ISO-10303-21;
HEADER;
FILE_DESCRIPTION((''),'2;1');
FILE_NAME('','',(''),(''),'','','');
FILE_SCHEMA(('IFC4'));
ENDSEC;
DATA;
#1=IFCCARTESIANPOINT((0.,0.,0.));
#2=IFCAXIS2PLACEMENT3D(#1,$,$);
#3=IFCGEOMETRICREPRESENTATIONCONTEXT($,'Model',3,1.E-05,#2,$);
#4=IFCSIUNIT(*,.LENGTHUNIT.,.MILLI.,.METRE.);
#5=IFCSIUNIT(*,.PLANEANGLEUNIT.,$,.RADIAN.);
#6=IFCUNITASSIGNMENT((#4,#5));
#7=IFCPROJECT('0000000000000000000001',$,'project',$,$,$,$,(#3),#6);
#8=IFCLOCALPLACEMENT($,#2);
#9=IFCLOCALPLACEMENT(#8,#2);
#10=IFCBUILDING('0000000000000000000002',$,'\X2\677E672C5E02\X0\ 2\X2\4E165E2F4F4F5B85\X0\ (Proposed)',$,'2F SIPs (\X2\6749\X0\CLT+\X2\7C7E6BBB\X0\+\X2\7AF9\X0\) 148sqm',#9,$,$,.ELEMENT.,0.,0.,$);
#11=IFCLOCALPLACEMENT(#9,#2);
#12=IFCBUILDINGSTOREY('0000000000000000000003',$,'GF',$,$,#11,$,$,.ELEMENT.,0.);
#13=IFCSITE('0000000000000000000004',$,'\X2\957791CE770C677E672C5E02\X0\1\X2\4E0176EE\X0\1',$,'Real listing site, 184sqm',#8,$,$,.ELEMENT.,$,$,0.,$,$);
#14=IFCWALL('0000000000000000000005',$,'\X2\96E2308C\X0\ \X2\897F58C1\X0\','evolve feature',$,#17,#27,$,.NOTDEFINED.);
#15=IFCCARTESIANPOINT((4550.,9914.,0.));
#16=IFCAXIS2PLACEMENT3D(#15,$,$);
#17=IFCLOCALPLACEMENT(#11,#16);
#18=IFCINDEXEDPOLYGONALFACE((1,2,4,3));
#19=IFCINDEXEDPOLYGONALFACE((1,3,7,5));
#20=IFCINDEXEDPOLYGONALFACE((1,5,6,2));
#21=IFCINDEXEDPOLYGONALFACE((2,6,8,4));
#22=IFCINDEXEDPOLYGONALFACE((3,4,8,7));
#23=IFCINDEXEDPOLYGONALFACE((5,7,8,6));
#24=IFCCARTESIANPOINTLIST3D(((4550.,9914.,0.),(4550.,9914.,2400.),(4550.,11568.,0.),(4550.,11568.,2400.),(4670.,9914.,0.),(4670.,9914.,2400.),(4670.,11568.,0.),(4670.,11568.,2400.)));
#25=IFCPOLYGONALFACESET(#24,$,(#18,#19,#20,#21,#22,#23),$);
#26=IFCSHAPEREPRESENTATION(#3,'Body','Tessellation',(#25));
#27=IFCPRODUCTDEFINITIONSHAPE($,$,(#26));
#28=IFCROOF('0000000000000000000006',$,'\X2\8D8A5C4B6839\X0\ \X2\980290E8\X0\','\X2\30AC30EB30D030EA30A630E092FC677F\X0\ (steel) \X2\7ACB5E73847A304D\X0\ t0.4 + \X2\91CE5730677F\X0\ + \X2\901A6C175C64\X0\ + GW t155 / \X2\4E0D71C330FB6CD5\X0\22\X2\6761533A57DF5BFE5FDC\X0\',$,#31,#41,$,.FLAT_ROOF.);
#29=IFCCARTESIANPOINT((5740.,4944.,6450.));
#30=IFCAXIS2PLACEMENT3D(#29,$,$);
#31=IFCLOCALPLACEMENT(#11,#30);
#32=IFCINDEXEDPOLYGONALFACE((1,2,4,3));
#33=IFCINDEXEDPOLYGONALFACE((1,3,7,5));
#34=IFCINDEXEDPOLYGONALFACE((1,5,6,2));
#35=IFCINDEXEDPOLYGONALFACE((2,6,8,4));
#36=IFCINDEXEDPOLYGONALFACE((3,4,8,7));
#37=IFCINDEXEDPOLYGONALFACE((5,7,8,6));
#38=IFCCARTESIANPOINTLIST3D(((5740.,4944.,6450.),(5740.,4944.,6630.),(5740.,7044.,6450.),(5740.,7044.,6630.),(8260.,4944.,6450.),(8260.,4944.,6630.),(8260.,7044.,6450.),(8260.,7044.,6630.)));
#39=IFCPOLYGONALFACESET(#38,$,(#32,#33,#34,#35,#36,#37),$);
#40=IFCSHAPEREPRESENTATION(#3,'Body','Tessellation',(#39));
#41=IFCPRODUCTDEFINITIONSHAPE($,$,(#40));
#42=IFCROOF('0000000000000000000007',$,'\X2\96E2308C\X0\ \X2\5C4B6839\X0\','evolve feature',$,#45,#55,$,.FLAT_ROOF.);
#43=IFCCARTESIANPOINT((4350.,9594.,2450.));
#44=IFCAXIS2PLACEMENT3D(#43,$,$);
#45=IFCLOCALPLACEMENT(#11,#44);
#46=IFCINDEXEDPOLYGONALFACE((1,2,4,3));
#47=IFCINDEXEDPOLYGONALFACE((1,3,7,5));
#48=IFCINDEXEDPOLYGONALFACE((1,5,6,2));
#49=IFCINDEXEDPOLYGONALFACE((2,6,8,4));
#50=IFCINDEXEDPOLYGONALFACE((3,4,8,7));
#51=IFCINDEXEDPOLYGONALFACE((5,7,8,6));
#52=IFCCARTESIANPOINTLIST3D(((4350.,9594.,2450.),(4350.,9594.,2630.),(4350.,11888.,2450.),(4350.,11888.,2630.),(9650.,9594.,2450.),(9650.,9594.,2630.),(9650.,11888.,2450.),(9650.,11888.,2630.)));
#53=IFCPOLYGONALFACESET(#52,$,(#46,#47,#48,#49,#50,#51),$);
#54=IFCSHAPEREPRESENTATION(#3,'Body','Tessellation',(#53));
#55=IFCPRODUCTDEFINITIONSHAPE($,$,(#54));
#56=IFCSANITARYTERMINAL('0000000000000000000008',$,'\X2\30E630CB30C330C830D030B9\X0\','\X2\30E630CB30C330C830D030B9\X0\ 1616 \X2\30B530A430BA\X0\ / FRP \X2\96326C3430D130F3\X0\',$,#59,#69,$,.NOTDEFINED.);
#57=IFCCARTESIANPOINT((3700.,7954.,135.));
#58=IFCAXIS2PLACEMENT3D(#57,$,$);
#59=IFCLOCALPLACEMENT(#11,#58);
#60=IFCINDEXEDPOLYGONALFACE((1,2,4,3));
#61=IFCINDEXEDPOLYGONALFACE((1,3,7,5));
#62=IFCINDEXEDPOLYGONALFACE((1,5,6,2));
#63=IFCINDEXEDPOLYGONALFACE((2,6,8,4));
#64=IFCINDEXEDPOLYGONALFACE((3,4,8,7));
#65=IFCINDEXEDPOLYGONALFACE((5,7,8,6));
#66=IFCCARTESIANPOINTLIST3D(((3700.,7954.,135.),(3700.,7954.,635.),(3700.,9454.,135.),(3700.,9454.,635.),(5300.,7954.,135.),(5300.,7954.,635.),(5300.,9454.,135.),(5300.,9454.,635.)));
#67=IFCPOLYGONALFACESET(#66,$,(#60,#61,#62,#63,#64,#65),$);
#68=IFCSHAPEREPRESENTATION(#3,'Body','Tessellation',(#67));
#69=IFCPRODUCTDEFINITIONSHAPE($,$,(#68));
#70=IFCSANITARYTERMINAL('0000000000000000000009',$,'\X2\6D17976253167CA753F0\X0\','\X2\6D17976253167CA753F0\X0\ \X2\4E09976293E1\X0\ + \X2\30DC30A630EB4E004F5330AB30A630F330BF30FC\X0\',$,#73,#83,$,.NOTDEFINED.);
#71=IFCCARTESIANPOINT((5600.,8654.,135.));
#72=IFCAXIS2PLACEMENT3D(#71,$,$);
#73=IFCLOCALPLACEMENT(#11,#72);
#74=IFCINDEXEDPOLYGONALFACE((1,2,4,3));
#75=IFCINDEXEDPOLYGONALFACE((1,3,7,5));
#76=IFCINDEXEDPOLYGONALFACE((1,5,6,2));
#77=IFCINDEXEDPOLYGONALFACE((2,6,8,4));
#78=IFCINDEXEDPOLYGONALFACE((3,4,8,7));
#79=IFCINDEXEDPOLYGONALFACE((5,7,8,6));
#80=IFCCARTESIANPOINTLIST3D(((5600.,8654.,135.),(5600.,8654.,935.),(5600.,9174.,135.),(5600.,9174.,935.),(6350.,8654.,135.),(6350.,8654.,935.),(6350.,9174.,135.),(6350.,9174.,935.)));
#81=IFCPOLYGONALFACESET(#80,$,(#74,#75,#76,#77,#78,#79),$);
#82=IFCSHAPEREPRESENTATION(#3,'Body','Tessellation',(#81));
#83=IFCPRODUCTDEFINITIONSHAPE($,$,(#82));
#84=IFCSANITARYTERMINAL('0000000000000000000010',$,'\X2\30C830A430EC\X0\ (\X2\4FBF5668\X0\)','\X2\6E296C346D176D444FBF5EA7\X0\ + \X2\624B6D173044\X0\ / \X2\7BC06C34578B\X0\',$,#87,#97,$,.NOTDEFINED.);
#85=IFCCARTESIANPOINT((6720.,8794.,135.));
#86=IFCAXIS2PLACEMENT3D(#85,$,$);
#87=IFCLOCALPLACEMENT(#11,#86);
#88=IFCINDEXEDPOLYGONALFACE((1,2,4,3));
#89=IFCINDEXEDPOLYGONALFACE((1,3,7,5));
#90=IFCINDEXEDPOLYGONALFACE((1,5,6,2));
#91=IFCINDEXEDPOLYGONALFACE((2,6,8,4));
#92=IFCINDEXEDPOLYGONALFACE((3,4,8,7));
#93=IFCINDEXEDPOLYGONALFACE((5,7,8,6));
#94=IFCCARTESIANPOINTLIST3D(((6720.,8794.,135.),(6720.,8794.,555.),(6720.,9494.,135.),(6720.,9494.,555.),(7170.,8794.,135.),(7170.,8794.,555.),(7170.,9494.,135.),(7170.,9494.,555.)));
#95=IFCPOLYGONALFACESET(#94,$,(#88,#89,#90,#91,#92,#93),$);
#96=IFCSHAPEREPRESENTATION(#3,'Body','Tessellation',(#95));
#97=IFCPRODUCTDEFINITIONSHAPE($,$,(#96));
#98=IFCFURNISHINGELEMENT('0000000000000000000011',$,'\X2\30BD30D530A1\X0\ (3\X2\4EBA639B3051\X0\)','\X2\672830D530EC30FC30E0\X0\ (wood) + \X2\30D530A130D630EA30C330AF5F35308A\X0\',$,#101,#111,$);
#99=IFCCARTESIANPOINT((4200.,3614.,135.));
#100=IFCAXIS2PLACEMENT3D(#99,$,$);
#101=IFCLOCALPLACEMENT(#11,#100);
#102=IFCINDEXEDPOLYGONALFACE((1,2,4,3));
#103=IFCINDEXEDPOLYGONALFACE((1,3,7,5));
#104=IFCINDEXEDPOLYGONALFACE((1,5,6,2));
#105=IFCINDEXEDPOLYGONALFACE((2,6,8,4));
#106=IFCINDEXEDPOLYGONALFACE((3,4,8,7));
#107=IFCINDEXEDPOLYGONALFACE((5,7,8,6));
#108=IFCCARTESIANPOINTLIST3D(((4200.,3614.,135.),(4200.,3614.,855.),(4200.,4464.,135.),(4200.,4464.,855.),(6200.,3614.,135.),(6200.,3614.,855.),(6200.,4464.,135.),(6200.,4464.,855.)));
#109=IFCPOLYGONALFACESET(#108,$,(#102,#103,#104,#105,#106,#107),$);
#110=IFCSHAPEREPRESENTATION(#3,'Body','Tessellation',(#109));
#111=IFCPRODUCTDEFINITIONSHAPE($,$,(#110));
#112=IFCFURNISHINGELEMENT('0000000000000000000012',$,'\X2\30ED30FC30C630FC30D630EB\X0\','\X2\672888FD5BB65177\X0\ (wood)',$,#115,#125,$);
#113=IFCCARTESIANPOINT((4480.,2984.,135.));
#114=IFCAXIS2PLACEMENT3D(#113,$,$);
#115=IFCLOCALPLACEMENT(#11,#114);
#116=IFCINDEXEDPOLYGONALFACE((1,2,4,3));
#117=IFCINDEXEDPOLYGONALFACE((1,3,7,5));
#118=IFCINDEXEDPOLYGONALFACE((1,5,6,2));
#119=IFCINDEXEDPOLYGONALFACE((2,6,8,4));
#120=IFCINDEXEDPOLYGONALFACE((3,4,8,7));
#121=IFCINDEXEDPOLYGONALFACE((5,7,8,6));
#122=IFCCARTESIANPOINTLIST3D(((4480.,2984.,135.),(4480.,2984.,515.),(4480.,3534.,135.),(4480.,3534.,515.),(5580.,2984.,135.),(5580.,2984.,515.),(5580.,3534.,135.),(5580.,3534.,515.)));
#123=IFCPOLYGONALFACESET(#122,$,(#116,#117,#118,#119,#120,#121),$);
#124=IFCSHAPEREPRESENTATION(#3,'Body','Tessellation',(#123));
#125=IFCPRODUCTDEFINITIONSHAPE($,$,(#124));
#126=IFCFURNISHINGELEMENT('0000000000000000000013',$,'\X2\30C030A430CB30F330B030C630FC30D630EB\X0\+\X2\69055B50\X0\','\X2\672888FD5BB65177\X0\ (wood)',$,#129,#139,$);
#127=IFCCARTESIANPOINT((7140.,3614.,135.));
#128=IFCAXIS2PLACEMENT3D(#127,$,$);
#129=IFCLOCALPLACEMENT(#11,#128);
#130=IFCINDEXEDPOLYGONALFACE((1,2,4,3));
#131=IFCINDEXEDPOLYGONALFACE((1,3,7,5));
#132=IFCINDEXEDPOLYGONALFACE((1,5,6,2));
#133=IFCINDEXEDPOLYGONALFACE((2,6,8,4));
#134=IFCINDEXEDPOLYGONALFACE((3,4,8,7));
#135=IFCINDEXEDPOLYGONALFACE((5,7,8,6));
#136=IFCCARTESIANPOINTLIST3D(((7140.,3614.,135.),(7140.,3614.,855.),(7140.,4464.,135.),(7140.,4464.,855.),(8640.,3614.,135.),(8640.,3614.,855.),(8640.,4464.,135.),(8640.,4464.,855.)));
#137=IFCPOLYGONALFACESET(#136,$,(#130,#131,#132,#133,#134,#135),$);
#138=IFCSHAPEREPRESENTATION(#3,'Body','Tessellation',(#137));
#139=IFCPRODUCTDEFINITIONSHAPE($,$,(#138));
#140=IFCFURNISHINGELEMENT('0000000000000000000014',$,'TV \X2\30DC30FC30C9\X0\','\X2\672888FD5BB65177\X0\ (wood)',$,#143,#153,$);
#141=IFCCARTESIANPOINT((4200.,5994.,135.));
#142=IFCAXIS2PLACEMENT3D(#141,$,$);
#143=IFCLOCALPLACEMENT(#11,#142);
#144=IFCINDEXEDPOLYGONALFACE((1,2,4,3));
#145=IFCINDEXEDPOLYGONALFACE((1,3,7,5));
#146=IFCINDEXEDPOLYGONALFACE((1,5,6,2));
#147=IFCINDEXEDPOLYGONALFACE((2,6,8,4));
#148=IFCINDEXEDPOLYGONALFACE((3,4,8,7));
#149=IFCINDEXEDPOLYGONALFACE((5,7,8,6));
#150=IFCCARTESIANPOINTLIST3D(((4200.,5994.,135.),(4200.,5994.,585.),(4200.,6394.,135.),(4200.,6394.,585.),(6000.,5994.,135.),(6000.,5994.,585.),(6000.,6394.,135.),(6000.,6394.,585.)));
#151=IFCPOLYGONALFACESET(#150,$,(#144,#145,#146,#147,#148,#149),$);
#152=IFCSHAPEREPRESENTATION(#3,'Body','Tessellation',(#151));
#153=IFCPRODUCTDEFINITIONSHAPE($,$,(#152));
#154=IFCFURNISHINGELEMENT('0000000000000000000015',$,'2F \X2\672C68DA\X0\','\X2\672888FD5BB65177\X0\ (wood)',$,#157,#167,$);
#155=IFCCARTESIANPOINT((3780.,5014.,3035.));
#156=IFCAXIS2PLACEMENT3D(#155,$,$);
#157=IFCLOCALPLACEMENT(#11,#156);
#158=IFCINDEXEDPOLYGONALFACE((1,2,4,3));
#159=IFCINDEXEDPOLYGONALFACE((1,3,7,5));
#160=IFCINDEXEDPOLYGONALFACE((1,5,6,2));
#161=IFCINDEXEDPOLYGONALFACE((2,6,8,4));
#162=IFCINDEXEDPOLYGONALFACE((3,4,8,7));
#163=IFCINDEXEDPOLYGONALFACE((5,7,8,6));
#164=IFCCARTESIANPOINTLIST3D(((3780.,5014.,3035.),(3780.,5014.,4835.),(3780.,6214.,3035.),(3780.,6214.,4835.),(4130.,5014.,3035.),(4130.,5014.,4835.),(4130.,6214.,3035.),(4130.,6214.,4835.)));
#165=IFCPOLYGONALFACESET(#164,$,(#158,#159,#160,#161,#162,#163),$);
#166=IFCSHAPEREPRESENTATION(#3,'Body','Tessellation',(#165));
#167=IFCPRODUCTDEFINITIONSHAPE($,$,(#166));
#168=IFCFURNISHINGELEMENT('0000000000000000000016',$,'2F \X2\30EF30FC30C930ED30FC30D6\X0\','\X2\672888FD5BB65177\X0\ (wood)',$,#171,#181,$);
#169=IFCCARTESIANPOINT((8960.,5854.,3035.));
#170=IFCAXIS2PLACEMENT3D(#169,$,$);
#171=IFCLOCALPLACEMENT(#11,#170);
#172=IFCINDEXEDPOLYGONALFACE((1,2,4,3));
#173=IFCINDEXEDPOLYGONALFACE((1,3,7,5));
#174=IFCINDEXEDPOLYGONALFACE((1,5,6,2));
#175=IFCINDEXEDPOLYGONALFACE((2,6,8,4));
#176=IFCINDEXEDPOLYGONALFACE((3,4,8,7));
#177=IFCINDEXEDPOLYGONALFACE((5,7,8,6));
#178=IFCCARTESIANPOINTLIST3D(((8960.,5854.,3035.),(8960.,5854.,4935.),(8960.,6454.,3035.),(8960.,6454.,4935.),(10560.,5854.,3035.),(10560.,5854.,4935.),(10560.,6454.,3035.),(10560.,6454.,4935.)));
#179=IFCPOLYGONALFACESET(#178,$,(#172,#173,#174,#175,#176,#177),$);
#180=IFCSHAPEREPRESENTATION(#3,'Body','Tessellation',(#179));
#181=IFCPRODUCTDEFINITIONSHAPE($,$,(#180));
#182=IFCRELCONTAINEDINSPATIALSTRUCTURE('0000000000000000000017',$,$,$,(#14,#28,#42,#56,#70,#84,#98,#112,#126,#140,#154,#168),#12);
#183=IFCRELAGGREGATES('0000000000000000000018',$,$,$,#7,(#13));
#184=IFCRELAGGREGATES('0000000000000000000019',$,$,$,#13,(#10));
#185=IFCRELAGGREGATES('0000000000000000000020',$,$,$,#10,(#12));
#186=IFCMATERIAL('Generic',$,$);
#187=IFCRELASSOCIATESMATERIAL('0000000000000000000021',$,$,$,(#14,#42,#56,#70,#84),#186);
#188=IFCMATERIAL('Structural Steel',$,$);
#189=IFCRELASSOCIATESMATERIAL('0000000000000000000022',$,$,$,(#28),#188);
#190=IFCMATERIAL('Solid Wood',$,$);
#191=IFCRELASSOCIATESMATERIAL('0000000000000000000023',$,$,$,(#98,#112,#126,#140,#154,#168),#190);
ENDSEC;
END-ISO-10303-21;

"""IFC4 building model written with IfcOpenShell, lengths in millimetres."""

from ifc_helpers import new_model, si_unit, frame, frame_2d, origin, place, context, project, spatial, rectangle, extrude, material, element, save


model = new_model("IFC4")

# Units and contexts
model_context = context("Model", 3, precision=1e-05, world=origin())
ifc_project = project(units=[si_unit("LENGTHUNIT", "METRE", prefix="MILLI"), si_unit("PLANEANGLEUNIT", "RADIAN")], contexts=[model_context])

# Site, building, storey
site_placement = place(None, origin())
site = spatial("IfcSite", under=ifc_project, at=site_placement, Name="長野県松本市1丁目1", ObjectType="Real listing site, 184sqm", CompositionType="ELEMENT", RefElevation=0.0)
building_placement = place(site_placement, origin())
building = spatial("IfcBuilding", under=site, at=building_placement, Name="松本市 2世帯住宅 (Proposed)", ObjectType="2F SIPs (杉CLT+籾殻+竹) 148sqm", CompositionType="ELEMENT", ElevationOfRefHeight=0.0, ElevationOfTerrain=0.0)
storey_placement = place(building_placement, origin())
storey = spatial("IfcBuildingStorey", under=building, at=storey_placement, Name="GF", CompositionType="ELEMENT", Elevation=0.0)

# Shared definitions
ifc_material_1 = material(Name="Generic")

# Shared definitions
ifc_material_2 = material(Name="Solid Wood")

# Wall
wall_1_placement = place(storey_placement, frame((4550.0, 9914.0, 0.0)))
element("IfcWall", 1, at=wall_1_placement, inside=storey, material=ifc_material_1, Name="離れ 西壁", Description="evolve feature", PredefinedType="NOTDEFINED", context=model_context, shape_type="SweptSolid", body=[
    extrude(rectangle(XDim=120.0, YDim=1654.0, at=frame_2d((60.0, 827.0))), frame((4550.0, 9914.0, 0.0)), (0.0, 0.0, 1.0), 2400.0),
])

# Roofs
ifc_material_3 = material(Name="Structural Steel")
roof_1_placement = place(storey_placement, frame((5740.0, 4944.0, 6450.0)))
element("IfcRoof", 2, at=roof_1_placement, inside=storey, material=ifc_material_3, Name="越屋根 頂部", Description="ガルバリウム鋼板 (steel) 立平葺き t0.4 + 野地板 + 通気層 + GW t155 / 不燃・法22条区域対応", PredefinedType="FLAT_ROOF", context=model_context, shape_type="SweptSolid", body=[
    extrude(rectangle(XDim=2520.0, YDim=2100.0, at=frame_2d((1260.0, 1050.0))), frame((5740.0, 4944.0, 6450.0)), (0.0, 0.0, 1.0), 180.0),
])
roof_2_placement = place(storey_placement, frame((4350.0, 9594.0, 2450.0)))
element("IfcRoof", 3, at=roof_2_placement, inside=storey, material=ifc_material_1, Name="離れ 屋根", Description="evolve feature", PredefinedType="FLAT_ROOF", context=model_context, shape_type="SweptSolid", body=[
    extrude(rectangle(XDim=5300.0, YDim=2294.0, at=frame_2d((2650.0, 1147.0))), frame((4350.0, 9594.0, 2450.0)), (0.0, 0.0, 1.0), 180.0),
])

# Sanitary terminals
sanitary_terminal_1_placement = place(storey_placement, frame((3700.0, 7954.0, 135.0)))
element("IfcSanitaryTerminal", 4, at=sanitary_terminal_1_placement, inside=storey, material=ifc_material_1, Name="ユニットバス", Description="ユニットバス 1616 サイズ / FRP 防水パン", PredefinedType="NOTDEFINED", context=model_context, shape_type="SweptSolid", body=[
    extrude(rectangle(XDim=1600.0, YDim=1500.0, at=frame_2d((800.0, 750.0))), frame((3700.0, 7954.0, 135.0)), (0.0, 0.0, 1.0), 500.0),
])
sanitary_terminal_2_placement = place(storey_placement, frame((5600.0, 8654.0, 135.0)))
element("IfcSanitaryTerminal", 5, at=sanitary_terminal_2_placement, inside=storey, material=ifc_material_1, Name="洗面化粧台", Description="洗面化粧台 三面鏡 + ボウル一体カウンター", PredefinedType="NOTDEFINED", context=model_context, shape_type="SweptSolid", body=[
    extrude(rectangle(XDim=750.0, YDim=520.0, at=frame_2d((375.0, 260.0))), frame((5600.0, 8654.0, 135.0)), (0.0, 0.0, 1.0), 800.0),
])
sanitary_terminal_3_placement = place(storey_placement, frame((6720.0, 8794.0, 135.0)))
element("IfcSanitaryTerminal", 6, at=sanitary_terminal_3_placement, inside=storey, material=ifc_material_1, Name="トイレ (便器)", Description="温水洗浄便座 + 手洗い / 節水型", PredefinedType="NOTDEFINED", context=model_context, shape_type="SweptSolid", body=[
    extrude(rectangle(XDim=450.0, YDim=700.0, at=frame_2d((225.0, 350.0))), frame((6720.0, 8794.0, 135.0)), (0.0, 0.0, 1.0), 420.0),
])

# Furnishing elements
furnishing_1_placement = place(storey_placement, frame((4200.0, 3614.0, 135.0)))
element("IfcFurnishingElement", 7, at=furnishing_1_placement, inside=storey, material=ifc_material_2, Name="ソファ (3人掛け)", Description="木フレーム (wood) + ファブリック張り", context=model_context, shape_type="SweptSolid", body=[
    extrude(rectangle(XDim=2000.0, YDim=850.0, at=frame_2d((1000.0, 425.0))), frame((4200.0, 3614.0, 135.0)), (0.0, 0.0, 1.0), 720.0),
])
furnishing_2_placement = place(storey_placement, frame((4480.0, 2984.0, 135.0)))
element("IfcFurnishingElement", 8, at=furnishing_2_placement, inside=storey, material=ifc_material_2, Name="ローテーブル", Description="木製家具 (wood)", context=model_context, shape_type="SweptSolid", body=[
    extrude(rectangle(XDim=1100.0, YDim=550.0, at=frame_2d((550.0, 275.0))), frame((4480.0, 2984.0, 135.0)), (0.0, 0.0, 1.0), 380.0),
])
furnishing_3_placement = place(storey_placement, frame((7140.0, 3614.0, 135.0)))
element("IfcFurnishingElement", 9, at=furnishing_3_placement, inside=storey, material=ifc_material_2, Name="ダイニングテーブル+椅子", Description="木製家具 (wood)", context=model_context, shape_type="SweptSolid", body=[
    extrude(rectangle(XDim=1500.0, YDim=850.0, at=frame_2d((750.0, 425.0))), frame((7140.0, 3614.0, 135.0)), (0.0, 0.0, 1.0), 720.0),
])
furnishing_4_placement = place(storey_placement, frame((4200.0, 5994.0, 135.0)))
element("IfcFurnishingElement", 10, at=furnishing_4_placement, inside=storey, material=ifc_material_2, Name="TV ボード", Description="木製家具 (wood)", context=model_context, shape_type="SweptSolid", body=[
    extrude(rectangle(XDim=1800.0, YDim=400.0, at=frame_2d((900.0, 200.0))), frame((4200.0, 5994.0, 135.0)), (0.0, 0.0, 1.0), 450.0),
])
furnishing_5_placement = place(storey_placement, frame((3780.0, 5014.0, 3035.0)))
element("IfcFurnishingElement", 11, at=furnishing_5_placement, inside=storey, material=ifc_material_2, Name="2F 本棚", Description="木製家具 (wood)", context=model_context, shape_type="SweptSolid", body=[
    extrude(rectangle(XDim=350.0, YDim=1200.0, at=frame_2d((175.0, 600.0))), frame((3780.0, 5014.0, 3035.0)), (0.0, 0.0, 1.0), 1800.0),
])
furnishing_6_placement = place(storey_placement, frame((8960.0, 5854.0, 3035.0)))
element("IfcFurnishingElement", 12, at=furnishing_6_placement, inside=storey, material=ifc_material_2, Name="2F ワードローブ", Description="木製家具 (wood)", context=model_context, shape_type="SweptSolid", body=[
    extrude(rectangle(XDim=1600.0, YDim=600.0, at=frame_2d((800.0, 300.0))), frame((8960.0, 5854.0, 3035.0)), (0.0, 0.0, 1.0), 1900.0),
])

save(model, "model.ifc")
